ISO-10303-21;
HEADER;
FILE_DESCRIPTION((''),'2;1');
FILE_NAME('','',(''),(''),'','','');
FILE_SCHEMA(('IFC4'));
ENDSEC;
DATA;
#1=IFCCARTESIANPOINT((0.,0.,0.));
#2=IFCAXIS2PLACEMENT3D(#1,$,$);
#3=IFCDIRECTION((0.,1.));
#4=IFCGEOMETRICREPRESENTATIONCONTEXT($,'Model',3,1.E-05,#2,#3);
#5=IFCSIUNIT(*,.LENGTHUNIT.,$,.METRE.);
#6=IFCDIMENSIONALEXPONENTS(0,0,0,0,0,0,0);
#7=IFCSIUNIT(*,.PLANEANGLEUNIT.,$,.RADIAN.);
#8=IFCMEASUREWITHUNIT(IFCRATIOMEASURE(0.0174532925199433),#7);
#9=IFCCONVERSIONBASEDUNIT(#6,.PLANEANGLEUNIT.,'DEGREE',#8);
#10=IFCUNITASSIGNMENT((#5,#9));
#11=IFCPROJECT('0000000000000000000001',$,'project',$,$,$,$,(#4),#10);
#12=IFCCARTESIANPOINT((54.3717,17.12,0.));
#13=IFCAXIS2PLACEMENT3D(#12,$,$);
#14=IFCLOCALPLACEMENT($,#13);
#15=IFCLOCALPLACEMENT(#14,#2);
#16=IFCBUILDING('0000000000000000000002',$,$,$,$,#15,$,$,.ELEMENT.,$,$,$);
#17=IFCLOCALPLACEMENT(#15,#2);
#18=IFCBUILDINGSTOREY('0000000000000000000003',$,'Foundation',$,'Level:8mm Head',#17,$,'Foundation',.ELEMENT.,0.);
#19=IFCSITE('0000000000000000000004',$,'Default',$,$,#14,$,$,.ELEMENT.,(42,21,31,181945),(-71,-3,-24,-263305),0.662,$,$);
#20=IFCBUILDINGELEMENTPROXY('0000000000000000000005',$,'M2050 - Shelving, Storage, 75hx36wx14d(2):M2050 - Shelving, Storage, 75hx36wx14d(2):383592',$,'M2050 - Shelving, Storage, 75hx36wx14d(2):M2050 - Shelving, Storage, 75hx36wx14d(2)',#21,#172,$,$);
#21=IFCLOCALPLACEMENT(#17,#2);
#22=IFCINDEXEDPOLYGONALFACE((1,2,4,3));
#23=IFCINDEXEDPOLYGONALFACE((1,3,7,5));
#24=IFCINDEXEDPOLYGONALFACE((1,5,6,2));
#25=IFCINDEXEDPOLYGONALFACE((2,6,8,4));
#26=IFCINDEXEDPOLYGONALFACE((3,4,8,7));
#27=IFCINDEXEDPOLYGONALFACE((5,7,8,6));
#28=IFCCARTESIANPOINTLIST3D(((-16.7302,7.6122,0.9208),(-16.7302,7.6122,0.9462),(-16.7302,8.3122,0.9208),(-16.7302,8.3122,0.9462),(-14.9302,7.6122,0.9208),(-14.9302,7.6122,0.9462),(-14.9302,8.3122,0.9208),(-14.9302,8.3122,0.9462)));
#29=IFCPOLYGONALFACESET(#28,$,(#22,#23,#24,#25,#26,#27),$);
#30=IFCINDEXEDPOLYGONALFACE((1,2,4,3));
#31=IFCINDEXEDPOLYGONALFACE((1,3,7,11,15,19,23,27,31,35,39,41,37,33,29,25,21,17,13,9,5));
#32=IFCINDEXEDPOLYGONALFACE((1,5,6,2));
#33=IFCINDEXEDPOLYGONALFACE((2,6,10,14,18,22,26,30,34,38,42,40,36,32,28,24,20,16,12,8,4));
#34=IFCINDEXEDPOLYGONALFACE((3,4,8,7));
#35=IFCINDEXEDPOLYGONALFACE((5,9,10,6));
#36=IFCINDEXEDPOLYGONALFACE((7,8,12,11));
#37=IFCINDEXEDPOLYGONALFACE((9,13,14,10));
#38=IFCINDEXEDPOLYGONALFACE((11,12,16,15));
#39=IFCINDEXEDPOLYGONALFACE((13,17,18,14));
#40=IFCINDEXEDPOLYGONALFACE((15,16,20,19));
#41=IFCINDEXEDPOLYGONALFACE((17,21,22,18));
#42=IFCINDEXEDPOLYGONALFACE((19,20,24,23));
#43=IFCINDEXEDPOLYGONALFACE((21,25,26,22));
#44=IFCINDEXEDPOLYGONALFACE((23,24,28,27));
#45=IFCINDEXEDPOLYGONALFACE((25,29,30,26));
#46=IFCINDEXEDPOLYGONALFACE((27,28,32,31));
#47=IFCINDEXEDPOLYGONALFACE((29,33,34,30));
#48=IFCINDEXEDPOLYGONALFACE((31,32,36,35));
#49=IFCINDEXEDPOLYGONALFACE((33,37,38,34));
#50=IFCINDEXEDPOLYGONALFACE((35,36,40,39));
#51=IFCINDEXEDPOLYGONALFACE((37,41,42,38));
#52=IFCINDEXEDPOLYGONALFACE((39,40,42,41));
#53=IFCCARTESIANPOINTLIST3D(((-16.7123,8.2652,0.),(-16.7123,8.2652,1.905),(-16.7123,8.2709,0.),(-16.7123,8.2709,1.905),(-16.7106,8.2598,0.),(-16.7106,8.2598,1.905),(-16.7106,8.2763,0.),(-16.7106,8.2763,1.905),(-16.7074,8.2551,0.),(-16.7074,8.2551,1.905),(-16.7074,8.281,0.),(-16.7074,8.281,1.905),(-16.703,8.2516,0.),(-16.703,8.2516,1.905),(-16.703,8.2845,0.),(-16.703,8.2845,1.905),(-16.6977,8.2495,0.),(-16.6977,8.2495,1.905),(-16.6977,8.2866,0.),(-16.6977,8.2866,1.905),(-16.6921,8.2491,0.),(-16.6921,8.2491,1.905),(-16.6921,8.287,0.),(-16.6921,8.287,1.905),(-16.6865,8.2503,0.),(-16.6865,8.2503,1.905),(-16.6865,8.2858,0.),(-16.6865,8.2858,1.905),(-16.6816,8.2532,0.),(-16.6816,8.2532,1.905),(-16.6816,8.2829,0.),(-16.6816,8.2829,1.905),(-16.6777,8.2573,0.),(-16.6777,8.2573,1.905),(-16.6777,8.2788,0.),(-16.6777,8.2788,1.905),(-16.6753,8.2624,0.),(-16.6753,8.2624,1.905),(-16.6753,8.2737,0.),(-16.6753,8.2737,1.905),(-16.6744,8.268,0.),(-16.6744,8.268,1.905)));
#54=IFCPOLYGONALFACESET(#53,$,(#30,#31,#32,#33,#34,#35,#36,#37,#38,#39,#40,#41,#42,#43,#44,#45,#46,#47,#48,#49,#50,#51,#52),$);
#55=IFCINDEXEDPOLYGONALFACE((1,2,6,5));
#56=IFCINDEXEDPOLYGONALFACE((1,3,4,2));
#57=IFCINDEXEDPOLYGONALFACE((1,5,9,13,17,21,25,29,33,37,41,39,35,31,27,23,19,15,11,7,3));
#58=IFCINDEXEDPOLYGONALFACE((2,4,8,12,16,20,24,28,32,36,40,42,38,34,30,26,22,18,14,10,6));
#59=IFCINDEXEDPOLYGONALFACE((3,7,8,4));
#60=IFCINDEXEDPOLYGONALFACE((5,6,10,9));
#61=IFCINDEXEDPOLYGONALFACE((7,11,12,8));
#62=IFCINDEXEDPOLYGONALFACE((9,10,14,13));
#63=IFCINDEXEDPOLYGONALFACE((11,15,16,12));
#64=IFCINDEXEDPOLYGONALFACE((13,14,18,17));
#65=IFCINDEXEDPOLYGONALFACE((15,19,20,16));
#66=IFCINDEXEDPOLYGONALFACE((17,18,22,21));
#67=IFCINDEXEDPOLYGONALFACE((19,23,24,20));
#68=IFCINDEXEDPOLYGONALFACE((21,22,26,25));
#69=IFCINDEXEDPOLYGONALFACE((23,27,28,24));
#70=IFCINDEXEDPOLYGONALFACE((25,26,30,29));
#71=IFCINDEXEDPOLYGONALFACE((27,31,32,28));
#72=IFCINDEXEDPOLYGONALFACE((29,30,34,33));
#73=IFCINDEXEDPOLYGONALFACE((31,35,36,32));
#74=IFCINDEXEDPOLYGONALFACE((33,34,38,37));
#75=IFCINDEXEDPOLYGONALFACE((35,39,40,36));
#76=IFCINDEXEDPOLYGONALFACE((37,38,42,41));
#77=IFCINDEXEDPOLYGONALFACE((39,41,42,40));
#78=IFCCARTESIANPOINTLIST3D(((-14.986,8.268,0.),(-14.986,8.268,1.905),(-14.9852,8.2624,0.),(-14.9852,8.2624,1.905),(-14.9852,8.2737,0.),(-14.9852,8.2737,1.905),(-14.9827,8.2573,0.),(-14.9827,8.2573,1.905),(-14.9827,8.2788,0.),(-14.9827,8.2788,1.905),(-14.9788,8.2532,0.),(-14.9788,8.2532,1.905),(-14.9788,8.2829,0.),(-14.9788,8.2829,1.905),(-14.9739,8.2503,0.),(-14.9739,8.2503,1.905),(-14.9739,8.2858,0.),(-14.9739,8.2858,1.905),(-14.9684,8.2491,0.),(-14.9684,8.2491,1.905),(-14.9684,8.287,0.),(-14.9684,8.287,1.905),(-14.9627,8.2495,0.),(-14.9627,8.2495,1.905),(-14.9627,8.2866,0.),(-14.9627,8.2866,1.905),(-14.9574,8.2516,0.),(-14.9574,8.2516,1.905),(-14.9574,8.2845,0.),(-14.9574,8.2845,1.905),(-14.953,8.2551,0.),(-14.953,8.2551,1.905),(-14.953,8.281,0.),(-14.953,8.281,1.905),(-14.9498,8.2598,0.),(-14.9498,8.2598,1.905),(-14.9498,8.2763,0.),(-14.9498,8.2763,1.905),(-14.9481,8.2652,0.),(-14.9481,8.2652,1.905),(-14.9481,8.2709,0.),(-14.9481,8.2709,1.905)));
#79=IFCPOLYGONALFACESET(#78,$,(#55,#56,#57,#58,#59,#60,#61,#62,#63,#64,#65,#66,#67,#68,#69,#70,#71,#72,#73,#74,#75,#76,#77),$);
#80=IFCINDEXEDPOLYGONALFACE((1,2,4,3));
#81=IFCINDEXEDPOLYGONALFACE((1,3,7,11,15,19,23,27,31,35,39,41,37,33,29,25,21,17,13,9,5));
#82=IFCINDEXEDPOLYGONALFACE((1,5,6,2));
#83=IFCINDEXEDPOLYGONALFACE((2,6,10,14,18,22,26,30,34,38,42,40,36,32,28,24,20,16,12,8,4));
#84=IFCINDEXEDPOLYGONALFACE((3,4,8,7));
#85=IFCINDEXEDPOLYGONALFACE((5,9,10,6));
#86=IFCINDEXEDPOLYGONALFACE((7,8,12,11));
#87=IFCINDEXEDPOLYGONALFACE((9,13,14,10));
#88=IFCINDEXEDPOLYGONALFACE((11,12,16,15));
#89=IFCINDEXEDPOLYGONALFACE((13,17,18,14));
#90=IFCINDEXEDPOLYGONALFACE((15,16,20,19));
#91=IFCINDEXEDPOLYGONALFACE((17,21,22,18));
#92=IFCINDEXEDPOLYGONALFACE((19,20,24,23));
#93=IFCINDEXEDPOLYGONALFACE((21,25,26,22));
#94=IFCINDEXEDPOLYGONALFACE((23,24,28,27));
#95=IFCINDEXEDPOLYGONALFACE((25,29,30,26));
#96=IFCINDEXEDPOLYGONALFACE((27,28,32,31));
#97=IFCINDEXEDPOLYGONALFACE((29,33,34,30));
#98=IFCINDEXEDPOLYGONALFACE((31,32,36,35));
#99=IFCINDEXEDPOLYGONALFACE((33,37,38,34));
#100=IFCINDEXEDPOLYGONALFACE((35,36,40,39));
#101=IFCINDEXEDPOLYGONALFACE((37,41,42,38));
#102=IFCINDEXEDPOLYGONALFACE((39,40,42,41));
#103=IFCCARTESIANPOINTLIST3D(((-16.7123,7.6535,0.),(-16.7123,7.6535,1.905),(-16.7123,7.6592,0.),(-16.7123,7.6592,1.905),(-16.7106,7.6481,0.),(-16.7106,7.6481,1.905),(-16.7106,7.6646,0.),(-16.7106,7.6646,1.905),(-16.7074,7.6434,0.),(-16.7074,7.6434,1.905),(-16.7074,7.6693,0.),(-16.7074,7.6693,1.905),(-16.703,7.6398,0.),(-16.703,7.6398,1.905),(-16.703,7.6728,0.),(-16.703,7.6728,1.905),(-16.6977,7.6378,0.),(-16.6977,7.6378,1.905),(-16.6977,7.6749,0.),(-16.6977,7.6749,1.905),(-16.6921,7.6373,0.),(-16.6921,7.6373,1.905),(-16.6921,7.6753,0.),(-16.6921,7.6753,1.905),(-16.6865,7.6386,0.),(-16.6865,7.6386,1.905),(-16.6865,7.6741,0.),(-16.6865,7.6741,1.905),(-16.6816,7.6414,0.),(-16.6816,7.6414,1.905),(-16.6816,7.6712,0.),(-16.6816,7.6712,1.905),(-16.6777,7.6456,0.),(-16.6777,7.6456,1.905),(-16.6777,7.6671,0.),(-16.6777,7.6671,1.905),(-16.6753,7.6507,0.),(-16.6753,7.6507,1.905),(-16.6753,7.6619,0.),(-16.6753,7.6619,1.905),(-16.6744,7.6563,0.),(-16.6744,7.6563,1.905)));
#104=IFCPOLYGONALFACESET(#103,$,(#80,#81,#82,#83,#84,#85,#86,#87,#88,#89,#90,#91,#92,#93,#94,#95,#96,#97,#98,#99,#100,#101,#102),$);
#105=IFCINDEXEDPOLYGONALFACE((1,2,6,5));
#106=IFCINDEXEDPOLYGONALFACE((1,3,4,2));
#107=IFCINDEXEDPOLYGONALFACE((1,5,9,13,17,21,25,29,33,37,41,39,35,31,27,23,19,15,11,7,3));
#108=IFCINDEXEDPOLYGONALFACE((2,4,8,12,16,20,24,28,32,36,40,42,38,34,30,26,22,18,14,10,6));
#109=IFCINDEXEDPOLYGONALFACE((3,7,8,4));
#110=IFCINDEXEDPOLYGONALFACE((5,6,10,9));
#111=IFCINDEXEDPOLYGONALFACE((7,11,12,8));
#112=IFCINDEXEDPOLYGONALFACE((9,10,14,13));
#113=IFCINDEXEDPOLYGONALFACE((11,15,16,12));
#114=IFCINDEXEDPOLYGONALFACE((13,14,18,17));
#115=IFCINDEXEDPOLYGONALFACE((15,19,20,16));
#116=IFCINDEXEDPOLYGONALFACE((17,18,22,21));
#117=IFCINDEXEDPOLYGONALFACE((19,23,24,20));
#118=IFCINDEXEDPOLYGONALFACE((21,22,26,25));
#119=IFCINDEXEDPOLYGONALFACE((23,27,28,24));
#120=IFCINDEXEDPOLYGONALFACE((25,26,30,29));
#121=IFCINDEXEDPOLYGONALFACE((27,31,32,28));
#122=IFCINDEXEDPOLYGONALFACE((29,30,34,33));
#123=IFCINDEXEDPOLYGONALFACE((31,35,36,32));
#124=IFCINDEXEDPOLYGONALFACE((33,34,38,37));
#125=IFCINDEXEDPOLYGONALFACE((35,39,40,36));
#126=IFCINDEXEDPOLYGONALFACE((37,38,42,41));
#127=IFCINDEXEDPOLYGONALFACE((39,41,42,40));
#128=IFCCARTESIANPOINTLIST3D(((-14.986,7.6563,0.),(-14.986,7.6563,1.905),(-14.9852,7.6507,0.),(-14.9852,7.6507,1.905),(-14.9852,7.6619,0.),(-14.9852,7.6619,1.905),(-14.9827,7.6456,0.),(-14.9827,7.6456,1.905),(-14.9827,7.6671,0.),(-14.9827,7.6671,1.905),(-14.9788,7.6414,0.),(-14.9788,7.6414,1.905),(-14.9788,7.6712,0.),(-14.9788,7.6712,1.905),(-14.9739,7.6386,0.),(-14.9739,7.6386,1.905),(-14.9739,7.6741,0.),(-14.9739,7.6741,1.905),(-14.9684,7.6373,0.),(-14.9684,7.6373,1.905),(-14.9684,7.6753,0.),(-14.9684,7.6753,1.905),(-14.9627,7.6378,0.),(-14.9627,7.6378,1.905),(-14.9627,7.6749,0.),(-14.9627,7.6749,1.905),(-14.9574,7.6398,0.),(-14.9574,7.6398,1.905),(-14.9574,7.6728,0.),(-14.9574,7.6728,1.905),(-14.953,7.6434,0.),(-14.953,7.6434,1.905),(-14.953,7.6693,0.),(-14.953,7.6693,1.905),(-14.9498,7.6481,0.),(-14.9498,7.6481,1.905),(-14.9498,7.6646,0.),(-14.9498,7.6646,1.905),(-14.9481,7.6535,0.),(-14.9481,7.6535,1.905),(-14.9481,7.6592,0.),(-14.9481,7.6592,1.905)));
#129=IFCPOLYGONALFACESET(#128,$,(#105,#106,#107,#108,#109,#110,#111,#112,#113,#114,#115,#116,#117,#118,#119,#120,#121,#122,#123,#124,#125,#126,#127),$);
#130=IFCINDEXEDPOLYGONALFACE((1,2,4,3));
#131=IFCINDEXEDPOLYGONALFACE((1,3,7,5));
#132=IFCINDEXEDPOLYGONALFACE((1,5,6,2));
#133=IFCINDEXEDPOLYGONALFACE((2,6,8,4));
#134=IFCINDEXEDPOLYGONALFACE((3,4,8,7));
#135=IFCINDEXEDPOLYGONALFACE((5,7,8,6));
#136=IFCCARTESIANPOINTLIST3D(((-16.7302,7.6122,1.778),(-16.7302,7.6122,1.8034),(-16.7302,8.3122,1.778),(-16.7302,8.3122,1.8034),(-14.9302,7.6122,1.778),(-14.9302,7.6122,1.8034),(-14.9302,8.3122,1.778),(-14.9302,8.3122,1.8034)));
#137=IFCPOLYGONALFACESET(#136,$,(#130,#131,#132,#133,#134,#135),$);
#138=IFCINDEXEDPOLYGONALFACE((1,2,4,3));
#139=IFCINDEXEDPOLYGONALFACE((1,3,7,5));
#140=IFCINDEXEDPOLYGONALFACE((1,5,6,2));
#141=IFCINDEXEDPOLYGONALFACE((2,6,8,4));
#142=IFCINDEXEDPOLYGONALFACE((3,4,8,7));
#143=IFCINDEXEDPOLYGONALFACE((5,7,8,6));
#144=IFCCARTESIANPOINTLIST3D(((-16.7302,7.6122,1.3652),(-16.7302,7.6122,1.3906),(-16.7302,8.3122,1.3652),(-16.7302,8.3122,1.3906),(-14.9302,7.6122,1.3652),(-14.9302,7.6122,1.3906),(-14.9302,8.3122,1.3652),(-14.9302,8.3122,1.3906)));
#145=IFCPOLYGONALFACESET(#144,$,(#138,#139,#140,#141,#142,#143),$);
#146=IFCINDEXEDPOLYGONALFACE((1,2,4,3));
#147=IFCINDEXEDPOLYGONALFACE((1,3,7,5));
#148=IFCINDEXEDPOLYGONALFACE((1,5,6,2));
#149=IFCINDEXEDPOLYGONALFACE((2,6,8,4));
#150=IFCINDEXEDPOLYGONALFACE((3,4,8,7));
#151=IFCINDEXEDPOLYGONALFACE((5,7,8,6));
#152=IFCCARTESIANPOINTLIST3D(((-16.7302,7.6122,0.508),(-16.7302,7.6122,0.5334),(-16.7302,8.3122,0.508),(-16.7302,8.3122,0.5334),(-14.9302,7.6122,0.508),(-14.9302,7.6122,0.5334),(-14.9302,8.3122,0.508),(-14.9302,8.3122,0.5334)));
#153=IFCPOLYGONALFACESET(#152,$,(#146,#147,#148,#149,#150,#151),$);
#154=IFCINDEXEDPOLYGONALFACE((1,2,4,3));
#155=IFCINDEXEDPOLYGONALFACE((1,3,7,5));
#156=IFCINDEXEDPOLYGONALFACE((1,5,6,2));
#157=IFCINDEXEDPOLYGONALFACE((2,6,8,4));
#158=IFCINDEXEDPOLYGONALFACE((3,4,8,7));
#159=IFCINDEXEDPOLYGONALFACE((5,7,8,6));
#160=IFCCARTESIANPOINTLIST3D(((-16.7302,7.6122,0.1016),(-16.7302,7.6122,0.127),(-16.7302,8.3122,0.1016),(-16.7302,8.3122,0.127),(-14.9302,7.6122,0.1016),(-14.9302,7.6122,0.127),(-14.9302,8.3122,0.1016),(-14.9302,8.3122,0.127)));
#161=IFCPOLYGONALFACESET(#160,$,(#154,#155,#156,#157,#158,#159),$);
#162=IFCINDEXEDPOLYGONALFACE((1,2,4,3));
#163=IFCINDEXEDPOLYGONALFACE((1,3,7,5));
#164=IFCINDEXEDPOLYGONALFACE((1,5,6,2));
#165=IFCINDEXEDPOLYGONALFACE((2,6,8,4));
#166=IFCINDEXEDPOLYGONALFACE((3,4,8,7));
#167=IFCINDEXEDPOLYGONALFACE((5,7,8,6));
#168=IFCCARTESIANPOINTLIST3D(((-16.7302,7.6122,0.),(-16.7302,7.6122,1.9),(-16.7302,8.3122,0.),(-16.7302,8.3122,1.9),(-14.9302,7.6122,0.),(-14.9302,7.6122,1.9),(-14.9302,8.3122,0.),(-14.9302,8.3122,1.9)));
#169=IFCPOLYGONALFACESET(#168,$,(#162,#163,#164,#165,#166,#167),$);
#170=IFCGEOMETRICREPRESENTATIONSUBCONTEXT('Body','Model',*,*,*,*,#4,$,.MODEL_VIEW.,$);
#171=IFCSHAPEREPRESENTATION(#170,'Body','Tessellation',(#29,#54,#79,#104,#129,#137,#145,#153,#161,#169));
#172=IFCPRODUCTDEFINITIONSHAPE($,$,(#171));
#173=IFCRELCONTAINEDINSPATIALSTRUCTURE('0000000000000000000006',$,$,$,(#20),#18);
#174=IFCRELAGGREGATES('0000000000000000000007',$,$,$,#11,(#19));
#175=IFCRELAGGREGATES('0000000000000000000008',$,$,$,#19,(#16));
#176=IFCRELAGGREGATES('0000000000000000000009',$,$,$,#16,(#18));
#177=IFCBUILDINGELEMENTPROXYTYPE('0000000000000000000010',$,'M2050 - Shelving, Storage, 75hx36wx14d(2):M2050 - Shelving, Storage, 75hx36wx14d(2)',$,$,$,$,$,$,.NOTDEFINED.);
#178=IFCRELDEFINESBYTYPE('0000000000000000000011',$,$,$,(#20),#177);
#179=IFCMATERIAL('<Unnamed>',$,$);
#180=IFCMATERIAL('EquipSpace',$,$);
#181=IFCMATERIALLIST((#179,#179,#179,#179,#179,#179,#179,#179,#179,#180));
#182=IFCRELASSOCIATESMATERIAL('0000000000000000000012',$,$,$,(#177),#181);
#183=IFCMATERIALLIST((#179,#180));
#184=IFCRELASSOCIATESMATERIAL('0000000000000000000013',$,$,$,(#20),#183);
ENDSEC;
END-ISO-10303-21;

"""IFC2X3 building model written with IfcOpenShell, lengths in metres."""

from ifc_helpers import new_model, entity, si_unit, converted_unit, direction, frame, frame_2d, origin, origin_2d_with_axis, place, context, subcontext, project, spatial, rectangle, circle, extrude, source, transform, mapped, material, material_list, type_object, type_shapes, element, save


model = new_model("IFC2X3")

# Units and contexts
model_context = context("Model", 3, precision=1e-05, world=origin(), true_north=direction((0.0, 1.0)))
body_context = subcontext(model_context, "Body", "Model", "MODEL_VIEW")
ifc_project = project(units=[si_unit("LENGTHUNIT", "METRE"), converted_unit("PLANEANGLEUNIT", "DEGREE", entity("IfcRatioMeasure", 0.0174532925199433), si_unit("PLANEANGLEUNIT", "RADIAN"), dimensions=[0, 0, 0, 0, 0, 0, 0])], contexts=[model_context])

# Site, building, storey
site_placement = place(None, frame((54.3717, 17.12, 0.0)))
site = spatial("IfcSite", under=ifc_project, at=site_placement, Name="Default", CompositionType="ELEMENT", RefLatitude=(42, 21, 31, 181945), RefLongitude=(-71, -3, -24, -263305), RefElevation=0.662)
building_placement = place(site_placement, origin())
building = spatial("IfcBuilding", under=site, at=building_placement, CompositionType="ELEMENT")
storey_placement = place(building_placement, origin())
storey = spatial("IfcBuildingStorey", under=building, at=storey_placement, Name="Foundation", ObjectType="Level:8mm Head", LongName="Foundation", CompositionType="ELEMENT", Elevation=0.0)

# Building element proxy
ifc_material_1 = material(Name="<Unnamed>")
ifc_material_2 = material(Name="EquipSpace")
ifc_material_list_1 = material_list([ifc_material_1, ifc_material_1, ifc_material_1, ifc_material_1, ifc_material_1, ifc_material_1, ifc_material_1, ifc_material_1, ifc_material_1, ifc_material_2])
building_element_proxy_type = type_object("IfcBuildingElementProxyType", Name="M2050 - Shelving, Storage, 75hx36wx14d(2):M2050 - Shelving, Storage, 75hx36wx14d(2)", PredefinedType="NOTDEFINED", material=ifc_material_list_1)
shared_shape = source(origin(), body_context, "Body", "SweptSolid", [
    extrude(rectangle(XDim=1.8, YDim=0.7, at=origin_2d_with_axis()), frame((0.0, 0.0, 0.9207), z_axis=(0.0, 0.0, 1.0), x_axis=(-1.0, 0.0, 0.0)), (0.0, 0.0, 1.0), 0.0254),
    extrude(circle(Radius=0.0191, at=origin_2d_with_axis()), frame((0.8633, -0.3059, 0.0), z_axis=(0.0, 0.0, 1.0), x_axis=(-1.0, 0.0, 0.0)), (0.0, 0.0, 1.0), 1.905),
    extrude(circle(Radius=0.0191, at=origin_2d_with_axis()), frame((-0.8633, -0.3059, 0.0)), (0.0, 0.0, 1.0), 1.905),
    extrude(circle(Radius=0.0191, at=origin_2d_with_axis()), frame((0.8633, 0.3059, 0.0), z_axis=(0.0, 0.0, 1.0), x_axis=(-1.0, 0.0, 0.0)), (0.0, 0.0, 1.0), 1.905),
    extrude(circle(Radius=0.0191, at=origin_2d_with_axis()), frame((-0.8633, 0.3059, 0.0)), (0.0, 0.0, 1.0), 1.905),
    extrude(rectangle(XDim=1.8, YDim=0.7, at=origin_2d_with_axis()), frame((0.0, 0.0, 1.778), z_axis=(0.0, 0.0, 1.0), x_axis=(-1.0, 0.0, 0.0)), (0.0, 0.0, 1.0), 0.0254),
    extrude(rectangle(XDim=1.8, YDim=0.7, at=origin_2d_with_axis()), frame((0.0, 0.0, 1.3653), z_axis=(0.0, 0.0, 1.0), x_axis=(-1.0, 0.0, 0.0)), (0.0, 0.0, 1.0), 0.0254),
    extrude(rectangle(XDim=1.8, YDim=0.7, at=origin_2d_with_axis()), frame((0.0, 0.0, 0.508), z_axis=(0.0, 0.0, 1.0), x_axis=(-1.0, 0.0, 0.0)), (0.0, 0.0, 1.0), 0.0254),
    extrude(rectangle(XDim=1.8, YDim=0.7, at=origin_2d_with_axis()), frame((0.0, 0.0, 0.1016), z_axis=(0.0, 0.0, 1.0), x_axis=(-1.0, 0.0, 0.0)), (0.0, 0.0, 1.0), 0.0254),
    extrude(rectangle(XDim=0.7, YDim=1.8, at=frame_2d((0.0, 0.18), x_axis=(1.0, 0.0))), frame((-0.18, 0.0, 0.0), z_axis=(0.0, 0.0, 1.0), x_axis=(0.0, -1.0, 0.0)), (0.0, 0.0, 1.0), 1.9),
])
type_shapes(building_element_proxy_type, [shared_shape])
ifc_material_list_2 = material_list([ifc_material_1, ifc_material_2])
proxy_1_placement = place(storey_placement, frame((-15.8302, 7.9622, 0.0), z_axis=(0.0, 0.0, 1.0), x_axis=(-1.0, 0.0, 0.0)))
element("IfcBuildingElementProxy", 1, at=proxy_1_placement, inside=storey, type_object=building_element_proxy_type, material=ifc_material_list_2, Name="M2050 - Shelving, Storage, 75hx36wx14d(2):M2050 - Shelving, Storage, 75hx36wx14d(2):383592", ObjectType="M2050 - Shelving, Storage, 75hx36wx14d(2):M2050 - Shelving, Storage, 75hx36wx14d(2)", context=body_context, shape_type="MappedRepresentation", body=[
    mapped(shared_shape, transform((0.0, 0.0, 0.0), scale=1.0)),
])

save(model, "model.ifc")
